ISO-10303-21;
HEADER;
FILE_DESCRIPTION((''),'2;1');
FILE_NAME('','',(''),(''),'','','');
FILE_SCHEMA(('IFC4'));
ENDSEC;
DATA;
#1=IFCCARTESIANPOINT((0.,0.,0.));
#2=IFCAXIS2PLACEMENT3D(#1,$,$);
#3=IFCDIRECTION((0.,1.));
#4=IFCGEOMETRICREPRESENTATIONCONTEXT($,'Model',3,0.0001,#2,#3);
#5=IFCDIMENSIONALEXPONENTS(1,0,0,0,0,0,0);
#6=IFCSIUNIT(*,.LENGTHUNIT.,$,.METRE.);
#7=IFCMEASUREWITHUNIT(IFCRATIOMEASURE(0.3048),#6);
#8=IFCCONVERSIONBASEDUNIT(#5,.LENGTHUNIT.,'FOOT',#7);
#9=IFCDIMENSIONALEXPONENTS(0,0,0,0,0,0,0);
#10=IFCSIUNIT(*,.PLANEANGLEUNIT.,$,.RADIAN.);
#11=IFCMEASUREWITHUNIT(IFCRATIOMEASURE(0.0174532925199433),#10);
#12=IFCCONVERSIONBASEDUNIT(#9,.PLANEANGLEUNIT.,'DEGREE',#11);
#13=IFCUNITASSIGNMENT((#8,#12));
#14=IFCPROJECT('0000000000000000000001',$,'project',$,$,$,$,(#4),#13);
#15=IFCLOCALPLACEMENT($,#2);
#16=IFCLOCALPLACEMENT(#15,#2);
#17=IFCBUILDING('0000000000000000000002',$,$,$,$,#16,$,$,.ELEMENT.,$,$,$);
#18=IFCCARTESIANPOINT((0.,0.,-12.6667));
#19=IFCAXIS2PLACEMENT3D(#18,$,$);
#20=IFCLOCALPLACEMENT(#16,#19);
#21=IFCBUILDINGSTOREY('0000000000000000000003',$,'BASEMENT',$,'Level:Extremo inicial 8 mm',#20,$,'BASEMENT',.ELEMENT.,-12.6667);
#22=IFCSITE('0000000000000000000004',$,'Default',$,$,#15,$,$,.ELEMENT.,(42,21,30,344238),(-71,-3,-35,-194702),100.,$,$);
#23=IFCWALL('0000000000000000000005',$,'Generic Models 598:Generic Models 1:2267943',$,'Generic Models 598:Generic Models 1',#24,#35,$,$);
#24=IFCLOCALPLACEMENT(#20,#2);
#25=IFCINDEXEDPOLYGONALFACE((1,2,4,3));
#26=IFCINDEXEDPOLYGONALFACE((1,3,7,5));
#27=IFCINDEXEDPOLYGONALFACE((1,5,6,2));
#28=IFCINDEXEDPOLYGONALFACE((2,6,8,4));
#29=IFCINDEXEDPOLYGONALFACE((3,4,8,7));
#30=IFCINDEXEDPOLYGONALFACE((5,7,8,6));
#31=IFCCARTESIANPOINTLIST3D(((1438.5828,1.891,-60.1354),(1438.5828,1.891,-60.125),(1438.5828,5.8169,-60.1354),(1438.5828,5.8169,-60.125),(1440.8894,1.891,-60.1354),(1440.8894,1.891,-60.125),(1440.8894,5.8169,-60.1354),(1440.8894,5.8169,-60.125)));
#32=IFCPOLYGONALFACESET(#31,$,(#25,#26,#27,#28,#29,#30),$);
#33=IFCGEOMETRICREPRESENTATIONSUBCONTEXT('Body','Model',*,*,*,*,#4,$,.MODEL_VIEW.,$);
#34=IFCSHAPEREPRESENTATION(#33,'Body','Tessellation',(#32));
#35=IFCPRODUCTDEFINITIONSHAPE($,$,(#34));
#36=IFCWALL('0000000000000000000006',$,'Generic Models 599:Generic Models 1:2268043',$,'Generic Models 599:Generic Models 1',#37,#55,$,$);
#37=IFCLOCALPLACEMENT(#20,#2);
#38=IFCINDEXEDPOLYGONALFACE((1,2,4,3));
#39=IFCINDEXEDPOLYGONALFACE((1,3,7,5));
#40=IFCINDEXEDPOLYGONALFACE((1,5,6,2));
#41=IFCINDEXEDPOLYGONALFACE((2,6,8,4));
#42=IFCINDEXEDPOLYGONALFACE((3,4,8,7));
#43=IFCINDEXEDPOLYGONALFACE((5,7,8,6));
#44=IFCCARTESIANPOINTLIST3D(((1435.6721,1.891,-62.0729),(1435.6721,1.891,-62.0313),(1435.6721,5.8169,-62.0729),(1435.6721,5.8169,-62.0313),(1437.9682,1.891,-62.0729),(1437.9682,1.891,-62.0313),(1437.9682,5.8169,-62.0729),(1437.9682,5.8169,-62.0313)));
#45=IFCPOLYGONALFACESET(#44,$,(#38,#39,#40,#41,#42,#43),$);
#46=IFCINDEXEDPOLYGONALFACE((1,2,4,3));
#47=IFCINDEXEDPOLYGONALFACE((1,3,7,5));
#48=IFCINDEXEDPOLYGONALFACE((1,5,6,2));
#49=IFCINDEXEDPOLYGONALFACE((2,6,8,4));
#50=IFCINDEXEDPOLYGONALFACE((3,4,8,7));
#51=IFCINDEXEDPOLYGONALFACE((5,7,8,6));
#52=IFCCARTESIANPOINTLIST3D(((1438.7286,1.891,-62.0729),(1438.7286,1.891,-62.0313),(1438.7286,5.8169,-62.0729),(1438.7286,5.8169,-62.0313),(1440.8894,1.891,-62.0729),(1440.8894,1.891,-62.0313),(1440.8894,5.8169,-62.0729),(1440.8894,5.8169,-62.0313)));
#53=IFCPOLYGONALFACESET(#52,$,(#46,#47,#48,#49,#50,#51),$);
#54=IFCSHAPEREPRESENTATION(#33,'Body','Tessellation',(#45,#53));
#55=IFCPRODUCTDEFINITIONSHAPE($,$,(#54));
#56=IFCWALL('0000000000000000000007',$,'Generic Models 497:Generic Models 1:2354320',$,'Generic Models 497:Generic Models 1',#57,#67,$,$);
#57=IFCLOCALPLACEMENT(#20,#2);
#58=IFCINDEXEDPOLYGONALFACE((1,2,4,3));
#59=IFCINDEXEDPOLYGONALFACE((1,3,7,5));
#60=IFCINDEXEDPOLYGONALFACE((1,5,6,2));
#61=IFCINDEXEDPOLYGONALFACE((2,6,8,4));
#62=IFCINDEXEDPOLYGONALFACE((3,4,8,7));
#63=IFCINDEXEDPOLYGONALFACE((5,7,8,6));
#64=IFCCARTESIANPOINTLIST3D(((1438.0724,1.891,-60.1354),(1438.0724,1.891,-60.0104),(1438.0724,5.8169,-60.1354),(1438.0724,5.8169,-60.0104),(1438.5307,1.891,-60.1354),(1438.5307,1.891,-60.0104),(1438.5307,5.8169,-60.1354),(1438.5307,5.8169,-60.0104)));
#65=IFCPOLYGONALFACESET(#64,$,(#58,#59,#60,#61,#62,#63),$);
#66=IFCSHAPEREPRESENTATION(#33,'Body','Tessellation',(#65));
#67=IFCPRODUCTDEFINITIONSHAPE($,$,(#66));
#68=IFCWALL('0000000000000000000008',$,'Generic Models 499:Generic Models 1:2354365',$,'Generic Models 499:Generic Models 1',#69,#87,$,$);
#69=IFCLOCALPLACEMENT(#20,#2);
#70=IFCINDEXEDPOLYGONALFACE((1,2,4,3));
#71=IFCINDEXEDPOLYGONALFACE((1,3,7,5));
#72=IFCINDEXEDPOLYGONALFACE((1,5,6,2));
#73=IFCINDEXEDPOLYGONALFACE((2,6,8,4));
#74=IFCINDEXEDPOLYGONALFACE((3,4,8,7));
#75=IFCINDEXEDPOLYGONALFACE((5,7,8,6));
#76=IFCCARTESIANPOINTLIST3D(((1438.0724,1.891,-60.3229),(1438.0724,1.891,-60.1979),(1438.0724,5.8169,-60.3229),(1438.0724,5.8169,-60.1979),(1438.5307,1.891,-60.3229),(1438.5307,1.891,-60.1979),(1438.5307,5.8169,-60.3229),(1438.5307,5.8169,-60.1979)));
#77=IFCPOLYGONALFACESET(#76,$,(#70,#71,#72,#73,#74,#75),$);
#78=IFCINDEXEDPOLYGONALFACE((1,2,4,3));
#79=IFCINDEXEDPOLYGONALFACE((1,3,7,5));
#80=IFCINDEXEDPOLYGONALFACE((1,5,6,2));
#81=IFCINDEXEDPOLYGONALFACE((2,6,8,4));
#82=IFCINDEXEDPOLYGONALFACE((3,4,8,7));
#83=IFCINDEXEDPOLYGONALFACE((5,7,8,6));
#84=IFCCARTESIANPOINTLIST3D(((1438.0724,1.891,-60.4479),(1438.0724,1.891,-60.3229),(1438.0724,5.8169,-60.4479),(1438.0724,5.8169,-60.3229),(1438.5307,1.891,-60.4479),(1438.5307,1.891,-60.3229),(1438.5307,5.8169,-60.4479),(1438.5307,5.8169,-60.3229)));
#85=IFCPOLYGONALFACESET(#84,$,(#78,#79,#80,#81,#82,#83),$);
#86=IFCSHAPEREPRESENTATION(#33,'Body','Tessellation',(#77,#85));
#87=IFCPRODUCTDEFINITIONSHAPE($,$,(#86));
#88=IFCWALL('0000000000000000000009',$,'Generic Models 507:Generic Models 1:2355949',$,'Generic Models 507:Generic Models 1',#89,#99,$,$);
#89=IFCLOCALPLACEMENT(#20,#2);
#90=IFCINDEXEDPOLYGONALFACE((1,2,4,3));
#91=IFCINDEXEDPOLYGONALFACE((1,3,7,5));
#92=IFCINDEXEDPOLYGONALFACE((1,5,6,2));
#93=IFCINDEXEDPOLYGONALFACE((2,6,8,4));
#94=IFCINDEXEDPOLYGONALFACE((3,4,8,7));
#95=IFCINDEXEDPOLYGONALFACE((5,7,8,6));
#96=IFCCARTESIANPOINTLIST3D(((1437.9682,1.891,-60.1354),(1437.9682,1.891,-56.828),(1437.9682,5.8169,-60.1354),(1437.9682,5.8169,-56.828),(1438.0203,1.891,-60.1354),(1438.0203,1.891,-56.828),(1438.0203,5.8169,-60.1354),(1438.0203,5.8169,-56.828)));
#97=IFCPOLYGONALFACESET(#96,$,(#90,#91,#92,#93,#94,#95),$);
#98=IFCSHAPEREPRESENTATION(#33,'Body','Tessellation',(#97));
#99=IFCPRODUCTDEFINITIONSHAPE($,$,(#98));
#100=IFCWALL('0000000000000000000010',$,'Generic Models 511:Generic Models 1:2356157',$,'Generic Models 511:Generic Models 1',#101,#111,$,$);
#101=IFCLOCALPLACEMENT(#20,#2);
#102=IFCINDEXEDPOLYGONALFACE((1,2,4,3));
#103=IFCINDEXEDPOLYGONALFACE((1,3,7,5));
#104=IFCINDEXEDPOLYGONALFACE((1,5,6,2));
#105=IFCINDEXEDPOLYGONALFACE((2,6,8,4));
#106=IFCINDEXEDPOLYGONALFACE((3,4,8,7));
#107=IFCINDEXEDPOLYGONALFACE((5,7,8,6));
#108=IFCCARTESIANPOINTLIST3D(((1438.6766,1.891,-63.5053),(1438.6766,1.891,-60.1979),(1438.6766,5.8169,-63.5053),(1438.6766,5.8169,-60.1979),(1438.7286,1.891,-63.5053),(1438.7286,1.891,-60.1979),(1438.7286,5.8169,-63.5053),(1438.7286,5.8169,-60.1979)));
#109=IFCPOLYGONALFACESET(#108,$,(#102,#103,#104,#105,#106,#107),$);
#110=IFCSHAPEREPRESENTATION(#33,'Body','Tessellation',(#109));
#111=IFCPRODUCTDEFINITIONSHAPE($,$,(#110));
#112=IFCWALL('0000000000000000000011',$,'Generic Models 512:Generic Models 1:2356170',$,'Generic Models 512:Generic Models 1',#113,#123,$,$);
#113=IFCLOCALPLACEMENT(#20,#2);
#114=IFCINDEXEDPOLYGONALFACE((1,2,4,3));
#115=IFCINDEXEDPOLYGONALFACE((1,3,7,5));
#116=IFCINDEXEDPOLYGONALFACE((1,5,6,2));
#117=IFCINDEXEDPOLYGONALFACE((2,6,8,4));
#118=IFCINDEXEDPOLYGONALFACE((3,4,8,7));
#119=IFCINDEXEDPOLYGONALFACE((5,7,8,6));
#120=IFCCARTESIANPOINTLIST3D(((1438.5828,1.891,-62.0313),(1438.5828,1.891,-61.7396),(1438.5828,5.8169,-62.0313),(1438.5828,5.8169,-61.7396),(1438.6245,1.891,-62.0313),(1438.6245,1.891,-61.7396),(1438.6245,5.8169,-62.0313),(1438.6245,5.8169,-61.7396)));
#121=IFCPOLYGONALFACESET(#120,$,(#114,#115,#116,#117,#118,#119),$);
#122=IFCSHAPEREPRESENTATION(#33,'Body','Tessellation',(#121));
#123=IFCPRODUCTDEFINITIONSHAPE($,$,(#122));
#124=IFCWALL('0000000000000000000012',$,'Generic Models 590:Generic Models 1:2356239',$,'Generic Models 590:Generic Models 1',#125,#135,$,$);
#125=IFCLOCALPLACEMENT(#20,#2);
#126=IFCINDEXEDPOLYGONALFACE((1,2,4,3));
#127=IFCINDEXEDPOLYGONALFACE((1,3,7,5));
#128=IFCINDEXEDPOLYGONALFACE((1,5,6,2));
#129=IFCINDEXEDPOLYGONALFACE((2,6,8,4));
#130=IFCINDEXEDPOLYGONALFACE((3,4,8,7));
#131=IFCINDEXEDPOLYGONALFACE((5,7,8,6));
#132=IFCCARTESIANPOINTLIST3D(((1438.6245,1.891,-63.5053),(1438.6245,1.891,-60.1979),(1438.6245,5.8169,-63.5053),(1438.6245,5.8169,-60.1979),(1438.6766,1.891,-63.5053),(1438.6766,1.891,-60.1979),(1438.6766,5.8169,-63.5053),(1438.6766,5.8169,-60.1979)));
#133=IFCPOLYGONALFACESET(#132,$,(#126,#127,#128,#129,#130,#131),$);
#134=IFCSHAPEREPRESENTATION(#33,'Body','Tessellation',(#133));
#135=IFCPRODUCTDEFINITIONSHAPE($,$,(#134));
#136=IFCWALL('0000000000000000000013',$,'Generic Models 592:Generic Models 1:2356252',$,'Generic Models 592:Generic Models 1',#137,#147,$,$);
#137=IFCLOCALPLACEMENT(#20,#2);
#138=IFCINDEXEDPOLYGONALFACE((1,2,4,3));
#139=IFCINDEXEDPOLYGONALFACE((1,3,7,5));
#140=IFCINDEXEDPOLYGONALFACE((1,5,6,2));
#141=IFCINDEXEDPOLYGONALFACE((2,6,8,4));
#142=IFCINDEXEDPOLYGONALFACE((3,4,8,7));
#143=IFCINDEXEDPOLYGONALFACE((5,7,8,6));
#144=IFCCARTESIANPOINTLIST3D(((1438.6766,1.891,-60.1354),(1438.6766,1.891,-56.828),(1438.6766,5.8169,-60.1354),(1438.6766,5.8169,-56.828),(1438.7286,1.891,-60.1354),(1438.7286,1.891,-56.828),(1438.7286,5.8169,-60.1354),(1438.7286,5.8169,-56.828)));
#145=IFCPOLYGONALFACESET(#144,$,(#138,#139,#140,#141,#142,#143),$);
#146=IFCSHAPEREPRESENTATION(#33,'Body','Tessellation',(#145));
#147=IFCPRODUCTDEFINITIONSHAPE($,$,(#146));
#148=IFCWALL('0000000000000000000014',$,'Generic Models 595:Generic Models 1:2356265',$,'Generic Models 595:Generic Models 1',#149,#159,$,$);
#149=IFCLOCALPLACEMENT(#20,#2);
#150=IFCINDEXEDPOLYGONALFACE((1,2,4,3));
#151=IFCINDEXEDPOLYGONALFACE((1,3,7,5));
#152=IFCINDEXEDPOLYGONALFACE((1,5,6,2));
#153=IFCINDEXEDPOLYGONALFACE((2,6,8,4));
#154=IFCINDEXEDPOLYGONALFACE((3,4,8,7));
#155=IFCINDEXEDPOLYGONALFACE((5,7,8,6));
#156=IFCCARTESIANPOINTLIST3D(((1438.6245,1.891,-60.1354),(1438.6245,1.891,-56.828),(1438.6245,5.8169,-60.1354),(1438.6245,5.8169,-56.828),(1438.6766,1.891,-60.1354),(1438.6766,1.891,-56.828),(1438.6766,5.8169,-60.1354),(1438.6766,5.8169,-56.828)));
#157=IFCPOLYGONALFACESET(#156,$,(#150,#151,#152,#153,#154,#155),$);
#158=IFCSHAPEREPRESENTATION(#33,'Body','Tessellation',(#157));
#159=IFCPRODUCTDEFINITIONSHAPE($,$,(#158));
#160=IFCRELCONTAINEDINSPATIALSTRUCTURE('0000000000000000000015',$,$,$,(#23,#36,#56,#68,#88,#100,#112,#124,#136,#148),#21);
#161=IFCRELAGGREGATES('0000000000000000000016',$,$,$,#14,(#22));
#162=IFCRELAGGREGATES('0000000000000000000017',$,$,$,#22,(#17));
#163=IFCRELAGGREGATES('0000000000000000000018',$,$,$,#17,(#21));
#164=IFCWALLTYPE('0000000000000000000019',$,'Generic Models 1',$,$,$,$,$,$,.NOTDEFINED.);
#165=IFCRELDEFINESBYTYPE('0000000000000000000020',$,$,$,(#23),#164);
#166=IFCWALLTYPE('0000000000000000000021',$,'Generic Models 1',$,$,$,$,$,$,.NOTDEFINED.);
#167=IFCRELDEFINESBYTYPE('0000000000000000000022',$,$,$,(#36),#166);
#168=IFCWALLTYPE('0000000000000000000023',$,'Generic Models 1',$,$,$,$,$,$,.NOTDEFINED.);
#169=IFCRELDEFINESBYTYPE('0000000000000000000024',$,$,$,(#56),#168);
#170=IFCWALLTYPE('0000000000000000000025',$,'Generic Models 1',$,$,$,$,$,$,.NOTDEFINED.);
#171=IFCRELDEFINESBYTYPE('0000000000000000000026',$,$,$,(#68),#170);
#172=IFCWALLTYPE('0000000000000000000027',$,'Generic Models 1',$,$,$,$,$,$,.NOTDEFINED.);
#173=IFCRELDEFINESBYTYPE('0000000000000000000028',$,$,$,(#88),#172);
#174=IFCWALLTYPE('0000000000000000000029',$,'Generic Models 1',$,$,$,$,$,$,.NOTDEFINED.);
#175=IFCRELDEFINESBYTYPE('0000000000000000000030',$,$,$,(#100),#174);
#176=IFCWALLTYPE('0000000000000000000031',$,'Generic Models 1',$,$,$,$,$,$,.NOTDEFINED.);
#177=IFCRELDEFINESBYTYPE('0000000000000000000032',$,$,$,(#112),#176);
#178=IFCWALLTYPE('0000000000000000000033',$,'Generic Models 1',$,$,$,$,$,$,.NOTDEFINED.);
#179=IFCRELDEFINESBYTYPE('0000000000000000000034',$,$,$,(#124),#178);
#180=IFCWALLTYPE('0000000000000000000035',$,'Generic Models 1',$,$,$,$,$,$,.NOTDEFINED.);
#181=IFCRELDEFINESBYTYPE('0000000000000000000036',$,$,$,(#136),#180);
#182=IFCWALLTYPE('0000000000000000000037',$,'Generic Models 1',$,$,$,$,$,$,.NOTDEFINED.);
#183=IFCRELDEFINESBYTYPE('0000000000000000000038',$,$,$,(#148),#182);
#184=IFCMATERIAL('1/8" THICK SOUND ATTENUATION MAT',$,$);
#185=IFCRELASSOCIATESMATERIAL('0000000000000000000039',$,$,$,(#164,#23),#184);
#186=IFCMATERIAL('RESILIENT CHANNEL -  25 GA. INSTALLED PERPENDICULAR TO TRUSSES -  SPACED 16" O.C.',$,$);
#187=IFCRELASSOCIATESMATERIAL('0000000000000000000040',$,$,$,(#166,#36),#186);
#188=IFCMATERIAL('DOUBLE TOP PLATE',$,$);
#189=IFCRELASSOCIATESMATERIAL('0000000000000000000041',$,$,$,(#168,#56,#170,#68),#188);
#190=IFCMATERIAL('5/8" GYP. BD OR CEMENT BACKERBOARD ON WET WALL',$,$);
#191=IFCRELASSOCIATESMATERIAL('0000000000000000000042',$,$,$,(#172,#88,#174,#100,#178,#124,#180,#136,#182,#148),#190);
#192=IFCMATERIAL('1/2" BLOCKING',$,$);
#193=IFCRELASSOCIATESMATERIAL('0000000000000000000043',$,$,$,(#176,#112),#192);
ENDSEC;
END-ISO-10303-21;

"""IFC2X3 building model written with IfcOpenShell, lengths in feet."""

from ifc_helpers import new_model, entity, si_unit, converted_unit, direction, frame, frame_2d, origin, origin_2d_with_axis, place, context, subcontext, project, spatial, rectangle, extrude, material, type_object, element, save


model = new_model("IFC2X3")

# Units and contexts
model_context = context("Model", 3, precision=0.0001, world=origin(), true_north=direction((0.0, 1.0)))
body_context = subcontext(model_context, "Body", "Model", "MODEL_VIEW")
ifc_project = project(units=[converted_unit("LENGTHUNIT", "FOOT", entity("IfcRatioMeasure", 0.3048), si_unit("LENGTHUNIT", "METRE"), dimensions=[1, 0, 0, 0, 0, 0, 0]), converted_unit("PLANEANGLEUNIT", "DEGREE", entity("IfcRatioMeasure", 0.0174532925199433), si_unit("PLANEANGLEUNIT", "RADIAN"), dimensions=[0, 0, 0, 0, 0, 0, 0])], contexts=[model_context])

# Site, building, storey
site_placement = place(None, origin())
site = spatial("IfcSite", under=ifc_project, at=site_placement, Name="Default", CompositionType="ELEMENT", RefLatitude=(42, 21, 30, 344238), RefLongitude=(-71, -3, -35, -194702), RefElevation=100.0)
building_placement = place(site_placement, origin())
building = spatial("IfcBuilding", under=site, at=building_placement, CompositionType="ELEMENT")
storey_placement = place(building_placement, frame((0.0, 0.0, -12.6667)))
storey = spatial("IfcBuildingStorey", under=building, at=storey_placement, Name="BASEMENT", ObjectType="Level:Extremo inicial 8 mm", LongName="BASEMENT", CompositionType="ELEMENT", Elevation=-12.6667)

# Walls
ifc_material_1 = material(Name="1/8\" THICK SOUND ATTENUATION MAT")
wall_type_1 = type_object("IfcWallType", Name="Generic Models 1", PredefinedType="NOTDEFINED", material=ifc_material_1)
wall_1_placement = place(storey_placement, frame((1438.5828, 1.891, -60.1354), z_axis=(0.0, 0.0, 1.0), x_axis=(0.0, 1.0, 0.0)))
element("IfcWall", 1, at=wall_1_placement, inside=storey, type_object=wall_type_1, material=ifc_material_1, Name="Generic Models 598:Generic Models 1:2267943", ObjectType="Generic Models 598:Generic Models 1", context=body_context, shape_type="SweptSolid", body=[
    extrude(rectangle(XDim=3.9258, YDim=2.3066, at=frame_2d((0.0, 0.0), x_axis=(1.0, 0.0))), frame((1.9629, -1.1533, 0.0)), (0.0, 0.0, 1.0), 0.0104),
])
ifc_material_2 = material(Name="RESILIENT CHANNEL -  25 GA. INSTALLED PERPENDICULAR TO TRUSSES -  SPACED 16\" O.C.")
wall_type_2 = type_object("IfcWallType", Name="Generic Models 1", PredefinedType="NOTDEFINED", material=ifc_material_2)
wall_2_placement = place(storey_placement, frame((1435.6721, 1.891, -62.0729)))
element("IfcWall", 2, at=wall_2_placement, inside=storey, type_object=wall_type_2, material=ifc_material_2, Name="Generic Models 599:Generic Models 1:2268043", ObjectType="Generic Models 599:Generic Models 1", context=body_context, shape_type="SweptSolid", body=[
    extrude(rectangle(XDim=3.9258, YDim=2.2962, at=frame_2d((0.0, 0.0), x_axis=(1.0, 0.0))), frame((1.1481, 1.9629, 0.0), z_axis=(0.0, 0.0, 1.0), x_axis=(0.0, 1.0, 0.0)), (0.0, 0.0, 1.0), 0.0417),
    extrude(rectangle(XDim=3.9258, YDim=2.1608, at=origin_2d_with_axis()), frame((4.137, 1.9629, 0.0), z_axis=(0.0, 0.0, 1.0), x_axis=(0.0, 1.0, 0.0)), (0.0, 0.0, 1.0), 0.0417),
])
ifc_material_3 = material(Name="DOUBLE TOP PLATE")
wall_type_3 = type_object("IfcWallType", Name="Generic Models 1", PredefinedType="NOTDEFINED", material=ifc_material_3)
wall_3_placement = place(storey_placement, frame((1438.0724, 1.891, -60.1354), z_axis=(0.0, 0.0, 1.0), x_axis=(0.0, 1.0, 0.0)))
element("IfcWall", 3, at=wall_3_placement, inside=storey, type_object=wall_type_3, material=ifc_material_3, Name="Generic Models 497:Generic Models 1:2354320", ObjectType="Generic Models 497:Generic Models 1", context=body_context, shape_type="SweptSolid", body=[
    extrude(rectangle(XDim=3.9258, YDim=0.4583, at=frame_2d((0.0, 0.0), x_axis=(1.0, 0.0))), frame((1.9629, -0.2292, 0.0)), (0.0, 0.0, 1.0), 0.125),
])
wall_type_4 = type_object("IfcWallType", Name="Generic Models 1", PredefinedType="NOTDEFINED", material=ifc_material_3)
wall_4_placement = place(storey_placement, frame((1438.0724, 1.891, -60.4479), z_axis=(0.0, 0.0, 1.0), x_axis=(0.0, 1.0, 0.0)))
element("IfcWall", 4, at=wall_4_placement, inside=storey, type_object=wall_type_4, material=ifc_material_3, Name="Generic Models 499:Generic Models 1:2354365", ObjectType="Generic Models 499:Generic Models 1", context=body_context, shape_type="SweptSolid", body=[
    extrude(rectangle(XDim=3.9258, YDim=0.4583, at=frame_2d((0.0, 0.0), x_axis=(1.0, 0.0))), frame((1.9629, -0.2292, 0.125)), (0.0, 0.0, 1.0), 0.125),
    extrude(rectangle(XDim=3.9258, YDim=0.4583, at=frame_2d((0.0, 0.0), x_axis=(1.0, 0.0))), frame((1.9629, -0.2292, 0.0)), (0.0, 0.0, 1.0), 0.125),
])
ifc_material_4 = material(Name="5/8\" GYP. BD OR CEMENT BACKERBOARD ON WET WALL")
wall_type_5 = type_object("IfcWallType", Name="Generic Models 1", PredefinedType="NOTDEFINED", material=ifc_material_4)
wall_5_placement = place(storey_placement, frame((1437.9682, 1.891, -60.1354), z_axis=(0.0, 0.0, 1.0), x_axis=(0.0, 1.0, 0.0)))
element("IfcWall", 5, at=wall_5_placement, inside=storey, type_object=wall_type_5, material=ifc_material_4, Name="Generic Models 507:Generic Models 1:2355949", ObjectType="Generic Models 507:Generic Models 1", context=body_context, shape_type="SweptSolid", body=[
    extrude(rectangle(XDim=3.9258, YDim=0.0521, at=frame_2d((0.0, 0.0), x_axis=(1.0, 0.0))), frame((1.9629, -0.026, 0.0)), (0.0, 0.0, 1.0), 3.3074),
])
wall_type_6 = type_object("IfcWallType", Name="Generic Models 1", PredefinedType="NOTDEFINED", material=ifc_material_4)
wall_6_placement = place(storey_placement, frame((1438.6766, 1.891, -63.5053), z_axis=(0.0, 0.0, 1.0), x_axis=(0.0, 1.0, 0.0)))
element("IfcWall", 6, at=wall_6_placement, inside=storey, type_object=wall_type_6, material=ifc_material_4, Name="Generic Models 511:Generic Models 1:2356157", ObjectType="Generic Models 511:Generic Models 1", context=body_context, shape_type="SweptSolid", body=[
    extrude(rectangle(XDim=3.9258, YDim=0.0521, at=frame_2d((0.0, 0.0), x_axis=(1.0, 0.0))), frame((1.9629, -0.026, 0.0)), (0.0, 0.0, 1.0), 3.3074),
])
ifc_material_5 = material(Name="1/2\" BLOCKING")
wall_type_7 = type_object("IfcWallType", Name="Generic Models 1", PredefinedType="NOTDEFINED", material=ifc_material_5)
wall_7_placement = place(storey_placement, frame((1438.5828, 1.891, -62.0313), z_axis=(0.0, 0.0, 1.0), x_axis=(0.0, 1.0, 0.0)))
element("IfcWall", 7, at=wall_7_placement, inside=storey, type_object=wall_type_7, material=ifc_material_5, Name="Generic Models 512:Generic Models 1:2356170", ObjectType="Generic Models 512:Generic Models 1", context=body_context, shape_type="SweptSolid", body=[
    extrude(rectangle(XDim=3.9258, YDim=0.0417, at=frame_2d((0.0, 0.0), x_axis=(1.0, 0.0))), frame((1.9629, -0.0208, 0.0)), (0.0, 0.0, 1.0), 0.2917),
])
wall_type_8 = type_object("IfcWallType", Name="Generic Models 1", PredefinedType="NOTDEFINED", material=ifc_material_4)
wall_8_placement = place(storey_placement, frame((1438.6245, 1.891, -63.5053), z_axis=(0.0, 0.0, 1.0), x_axis=(0.0, 1.0, 0.0)))
element("IfcWall", 8, at=wall_8_placement, inside=storey, type_object=wall_type_8, material=ifc_material_4, Name="Generic Models 590:Generic Models 1:2356239", ObjectType="Generic Models 590:Generic Models 1", context=body_context, shape_type="SweptSolid", body=[
    extrude(rectangle(XDim=3.9258, YDim=0.0521, at=frame_2d((0.0, 0.0), x_axis=(1.0, 0.0))), frame((1.9629, -0.026, 0.0)), (0.0, 0.0, 1.0), 3.3074),
])
wall_type_9 = type_object("IfcWallType", Name="Generic Models 1", PredefinedType="NOTDEFINED", material=ifc_material_4)
wall_9_placement = place(storey_placement, frame((1438.6766, 1.891, -60.1354), z_axis=(0.0, 0.0, 1.0), x_axis=(0.0, 1.0, 0.0)))
element("IfcWall", 9, at=wall_9_placement, inside=storey, type_object=wall_type_9, material=ifc_material_4, Name="Generic Models 592:Generic Models 1:2356252", ObjectType="Generic Models 592:Generic Models 1", context=body_context, shape_type="SweptSolid", body=[
    extrude(rectangle(XDim=3.9258, YDim=0.0521, at=frame_2d((0.0, 0.0), x_axis=(1.0, 0.0))), frame((1.9629, -0.026, 0.0)), (0.0, 0.0, 1.0), 3.3074),
])
wall_type_10 = type_object("IfcWallType", Name="Generic Models 1", PredefinedType="NOTDEFINED", material=ifc_material_4)
wall_10_placement = place(storey_placement, frame((1438.6245, 1.891, -60.1354), z_axis=(0.0, 0.0, 1.0), x_axis=(0.0, 1.0, 0.0)))
element("IfcWall", 10, at=wall_10_placement, inside=storey, type_object=wall_type_10, material=ifc_material_4, Name="Generic Models 595:Generic Models 1:2356265", ObjectType="Generic Models 595:Generic Models 1", context=body_context, shape_type="SweptSolid", body=[
    extrude(rectangle(XDim=3.9258, YDim=0.0521, at=frame_2d((0.0, 0.0), x_axis=(1.0, 0.0))), frame((1.9629, -0.026, 0.0)), (0.0, 0.0, 1.0), 3.3074),
])

save(model, "model.ifc")
